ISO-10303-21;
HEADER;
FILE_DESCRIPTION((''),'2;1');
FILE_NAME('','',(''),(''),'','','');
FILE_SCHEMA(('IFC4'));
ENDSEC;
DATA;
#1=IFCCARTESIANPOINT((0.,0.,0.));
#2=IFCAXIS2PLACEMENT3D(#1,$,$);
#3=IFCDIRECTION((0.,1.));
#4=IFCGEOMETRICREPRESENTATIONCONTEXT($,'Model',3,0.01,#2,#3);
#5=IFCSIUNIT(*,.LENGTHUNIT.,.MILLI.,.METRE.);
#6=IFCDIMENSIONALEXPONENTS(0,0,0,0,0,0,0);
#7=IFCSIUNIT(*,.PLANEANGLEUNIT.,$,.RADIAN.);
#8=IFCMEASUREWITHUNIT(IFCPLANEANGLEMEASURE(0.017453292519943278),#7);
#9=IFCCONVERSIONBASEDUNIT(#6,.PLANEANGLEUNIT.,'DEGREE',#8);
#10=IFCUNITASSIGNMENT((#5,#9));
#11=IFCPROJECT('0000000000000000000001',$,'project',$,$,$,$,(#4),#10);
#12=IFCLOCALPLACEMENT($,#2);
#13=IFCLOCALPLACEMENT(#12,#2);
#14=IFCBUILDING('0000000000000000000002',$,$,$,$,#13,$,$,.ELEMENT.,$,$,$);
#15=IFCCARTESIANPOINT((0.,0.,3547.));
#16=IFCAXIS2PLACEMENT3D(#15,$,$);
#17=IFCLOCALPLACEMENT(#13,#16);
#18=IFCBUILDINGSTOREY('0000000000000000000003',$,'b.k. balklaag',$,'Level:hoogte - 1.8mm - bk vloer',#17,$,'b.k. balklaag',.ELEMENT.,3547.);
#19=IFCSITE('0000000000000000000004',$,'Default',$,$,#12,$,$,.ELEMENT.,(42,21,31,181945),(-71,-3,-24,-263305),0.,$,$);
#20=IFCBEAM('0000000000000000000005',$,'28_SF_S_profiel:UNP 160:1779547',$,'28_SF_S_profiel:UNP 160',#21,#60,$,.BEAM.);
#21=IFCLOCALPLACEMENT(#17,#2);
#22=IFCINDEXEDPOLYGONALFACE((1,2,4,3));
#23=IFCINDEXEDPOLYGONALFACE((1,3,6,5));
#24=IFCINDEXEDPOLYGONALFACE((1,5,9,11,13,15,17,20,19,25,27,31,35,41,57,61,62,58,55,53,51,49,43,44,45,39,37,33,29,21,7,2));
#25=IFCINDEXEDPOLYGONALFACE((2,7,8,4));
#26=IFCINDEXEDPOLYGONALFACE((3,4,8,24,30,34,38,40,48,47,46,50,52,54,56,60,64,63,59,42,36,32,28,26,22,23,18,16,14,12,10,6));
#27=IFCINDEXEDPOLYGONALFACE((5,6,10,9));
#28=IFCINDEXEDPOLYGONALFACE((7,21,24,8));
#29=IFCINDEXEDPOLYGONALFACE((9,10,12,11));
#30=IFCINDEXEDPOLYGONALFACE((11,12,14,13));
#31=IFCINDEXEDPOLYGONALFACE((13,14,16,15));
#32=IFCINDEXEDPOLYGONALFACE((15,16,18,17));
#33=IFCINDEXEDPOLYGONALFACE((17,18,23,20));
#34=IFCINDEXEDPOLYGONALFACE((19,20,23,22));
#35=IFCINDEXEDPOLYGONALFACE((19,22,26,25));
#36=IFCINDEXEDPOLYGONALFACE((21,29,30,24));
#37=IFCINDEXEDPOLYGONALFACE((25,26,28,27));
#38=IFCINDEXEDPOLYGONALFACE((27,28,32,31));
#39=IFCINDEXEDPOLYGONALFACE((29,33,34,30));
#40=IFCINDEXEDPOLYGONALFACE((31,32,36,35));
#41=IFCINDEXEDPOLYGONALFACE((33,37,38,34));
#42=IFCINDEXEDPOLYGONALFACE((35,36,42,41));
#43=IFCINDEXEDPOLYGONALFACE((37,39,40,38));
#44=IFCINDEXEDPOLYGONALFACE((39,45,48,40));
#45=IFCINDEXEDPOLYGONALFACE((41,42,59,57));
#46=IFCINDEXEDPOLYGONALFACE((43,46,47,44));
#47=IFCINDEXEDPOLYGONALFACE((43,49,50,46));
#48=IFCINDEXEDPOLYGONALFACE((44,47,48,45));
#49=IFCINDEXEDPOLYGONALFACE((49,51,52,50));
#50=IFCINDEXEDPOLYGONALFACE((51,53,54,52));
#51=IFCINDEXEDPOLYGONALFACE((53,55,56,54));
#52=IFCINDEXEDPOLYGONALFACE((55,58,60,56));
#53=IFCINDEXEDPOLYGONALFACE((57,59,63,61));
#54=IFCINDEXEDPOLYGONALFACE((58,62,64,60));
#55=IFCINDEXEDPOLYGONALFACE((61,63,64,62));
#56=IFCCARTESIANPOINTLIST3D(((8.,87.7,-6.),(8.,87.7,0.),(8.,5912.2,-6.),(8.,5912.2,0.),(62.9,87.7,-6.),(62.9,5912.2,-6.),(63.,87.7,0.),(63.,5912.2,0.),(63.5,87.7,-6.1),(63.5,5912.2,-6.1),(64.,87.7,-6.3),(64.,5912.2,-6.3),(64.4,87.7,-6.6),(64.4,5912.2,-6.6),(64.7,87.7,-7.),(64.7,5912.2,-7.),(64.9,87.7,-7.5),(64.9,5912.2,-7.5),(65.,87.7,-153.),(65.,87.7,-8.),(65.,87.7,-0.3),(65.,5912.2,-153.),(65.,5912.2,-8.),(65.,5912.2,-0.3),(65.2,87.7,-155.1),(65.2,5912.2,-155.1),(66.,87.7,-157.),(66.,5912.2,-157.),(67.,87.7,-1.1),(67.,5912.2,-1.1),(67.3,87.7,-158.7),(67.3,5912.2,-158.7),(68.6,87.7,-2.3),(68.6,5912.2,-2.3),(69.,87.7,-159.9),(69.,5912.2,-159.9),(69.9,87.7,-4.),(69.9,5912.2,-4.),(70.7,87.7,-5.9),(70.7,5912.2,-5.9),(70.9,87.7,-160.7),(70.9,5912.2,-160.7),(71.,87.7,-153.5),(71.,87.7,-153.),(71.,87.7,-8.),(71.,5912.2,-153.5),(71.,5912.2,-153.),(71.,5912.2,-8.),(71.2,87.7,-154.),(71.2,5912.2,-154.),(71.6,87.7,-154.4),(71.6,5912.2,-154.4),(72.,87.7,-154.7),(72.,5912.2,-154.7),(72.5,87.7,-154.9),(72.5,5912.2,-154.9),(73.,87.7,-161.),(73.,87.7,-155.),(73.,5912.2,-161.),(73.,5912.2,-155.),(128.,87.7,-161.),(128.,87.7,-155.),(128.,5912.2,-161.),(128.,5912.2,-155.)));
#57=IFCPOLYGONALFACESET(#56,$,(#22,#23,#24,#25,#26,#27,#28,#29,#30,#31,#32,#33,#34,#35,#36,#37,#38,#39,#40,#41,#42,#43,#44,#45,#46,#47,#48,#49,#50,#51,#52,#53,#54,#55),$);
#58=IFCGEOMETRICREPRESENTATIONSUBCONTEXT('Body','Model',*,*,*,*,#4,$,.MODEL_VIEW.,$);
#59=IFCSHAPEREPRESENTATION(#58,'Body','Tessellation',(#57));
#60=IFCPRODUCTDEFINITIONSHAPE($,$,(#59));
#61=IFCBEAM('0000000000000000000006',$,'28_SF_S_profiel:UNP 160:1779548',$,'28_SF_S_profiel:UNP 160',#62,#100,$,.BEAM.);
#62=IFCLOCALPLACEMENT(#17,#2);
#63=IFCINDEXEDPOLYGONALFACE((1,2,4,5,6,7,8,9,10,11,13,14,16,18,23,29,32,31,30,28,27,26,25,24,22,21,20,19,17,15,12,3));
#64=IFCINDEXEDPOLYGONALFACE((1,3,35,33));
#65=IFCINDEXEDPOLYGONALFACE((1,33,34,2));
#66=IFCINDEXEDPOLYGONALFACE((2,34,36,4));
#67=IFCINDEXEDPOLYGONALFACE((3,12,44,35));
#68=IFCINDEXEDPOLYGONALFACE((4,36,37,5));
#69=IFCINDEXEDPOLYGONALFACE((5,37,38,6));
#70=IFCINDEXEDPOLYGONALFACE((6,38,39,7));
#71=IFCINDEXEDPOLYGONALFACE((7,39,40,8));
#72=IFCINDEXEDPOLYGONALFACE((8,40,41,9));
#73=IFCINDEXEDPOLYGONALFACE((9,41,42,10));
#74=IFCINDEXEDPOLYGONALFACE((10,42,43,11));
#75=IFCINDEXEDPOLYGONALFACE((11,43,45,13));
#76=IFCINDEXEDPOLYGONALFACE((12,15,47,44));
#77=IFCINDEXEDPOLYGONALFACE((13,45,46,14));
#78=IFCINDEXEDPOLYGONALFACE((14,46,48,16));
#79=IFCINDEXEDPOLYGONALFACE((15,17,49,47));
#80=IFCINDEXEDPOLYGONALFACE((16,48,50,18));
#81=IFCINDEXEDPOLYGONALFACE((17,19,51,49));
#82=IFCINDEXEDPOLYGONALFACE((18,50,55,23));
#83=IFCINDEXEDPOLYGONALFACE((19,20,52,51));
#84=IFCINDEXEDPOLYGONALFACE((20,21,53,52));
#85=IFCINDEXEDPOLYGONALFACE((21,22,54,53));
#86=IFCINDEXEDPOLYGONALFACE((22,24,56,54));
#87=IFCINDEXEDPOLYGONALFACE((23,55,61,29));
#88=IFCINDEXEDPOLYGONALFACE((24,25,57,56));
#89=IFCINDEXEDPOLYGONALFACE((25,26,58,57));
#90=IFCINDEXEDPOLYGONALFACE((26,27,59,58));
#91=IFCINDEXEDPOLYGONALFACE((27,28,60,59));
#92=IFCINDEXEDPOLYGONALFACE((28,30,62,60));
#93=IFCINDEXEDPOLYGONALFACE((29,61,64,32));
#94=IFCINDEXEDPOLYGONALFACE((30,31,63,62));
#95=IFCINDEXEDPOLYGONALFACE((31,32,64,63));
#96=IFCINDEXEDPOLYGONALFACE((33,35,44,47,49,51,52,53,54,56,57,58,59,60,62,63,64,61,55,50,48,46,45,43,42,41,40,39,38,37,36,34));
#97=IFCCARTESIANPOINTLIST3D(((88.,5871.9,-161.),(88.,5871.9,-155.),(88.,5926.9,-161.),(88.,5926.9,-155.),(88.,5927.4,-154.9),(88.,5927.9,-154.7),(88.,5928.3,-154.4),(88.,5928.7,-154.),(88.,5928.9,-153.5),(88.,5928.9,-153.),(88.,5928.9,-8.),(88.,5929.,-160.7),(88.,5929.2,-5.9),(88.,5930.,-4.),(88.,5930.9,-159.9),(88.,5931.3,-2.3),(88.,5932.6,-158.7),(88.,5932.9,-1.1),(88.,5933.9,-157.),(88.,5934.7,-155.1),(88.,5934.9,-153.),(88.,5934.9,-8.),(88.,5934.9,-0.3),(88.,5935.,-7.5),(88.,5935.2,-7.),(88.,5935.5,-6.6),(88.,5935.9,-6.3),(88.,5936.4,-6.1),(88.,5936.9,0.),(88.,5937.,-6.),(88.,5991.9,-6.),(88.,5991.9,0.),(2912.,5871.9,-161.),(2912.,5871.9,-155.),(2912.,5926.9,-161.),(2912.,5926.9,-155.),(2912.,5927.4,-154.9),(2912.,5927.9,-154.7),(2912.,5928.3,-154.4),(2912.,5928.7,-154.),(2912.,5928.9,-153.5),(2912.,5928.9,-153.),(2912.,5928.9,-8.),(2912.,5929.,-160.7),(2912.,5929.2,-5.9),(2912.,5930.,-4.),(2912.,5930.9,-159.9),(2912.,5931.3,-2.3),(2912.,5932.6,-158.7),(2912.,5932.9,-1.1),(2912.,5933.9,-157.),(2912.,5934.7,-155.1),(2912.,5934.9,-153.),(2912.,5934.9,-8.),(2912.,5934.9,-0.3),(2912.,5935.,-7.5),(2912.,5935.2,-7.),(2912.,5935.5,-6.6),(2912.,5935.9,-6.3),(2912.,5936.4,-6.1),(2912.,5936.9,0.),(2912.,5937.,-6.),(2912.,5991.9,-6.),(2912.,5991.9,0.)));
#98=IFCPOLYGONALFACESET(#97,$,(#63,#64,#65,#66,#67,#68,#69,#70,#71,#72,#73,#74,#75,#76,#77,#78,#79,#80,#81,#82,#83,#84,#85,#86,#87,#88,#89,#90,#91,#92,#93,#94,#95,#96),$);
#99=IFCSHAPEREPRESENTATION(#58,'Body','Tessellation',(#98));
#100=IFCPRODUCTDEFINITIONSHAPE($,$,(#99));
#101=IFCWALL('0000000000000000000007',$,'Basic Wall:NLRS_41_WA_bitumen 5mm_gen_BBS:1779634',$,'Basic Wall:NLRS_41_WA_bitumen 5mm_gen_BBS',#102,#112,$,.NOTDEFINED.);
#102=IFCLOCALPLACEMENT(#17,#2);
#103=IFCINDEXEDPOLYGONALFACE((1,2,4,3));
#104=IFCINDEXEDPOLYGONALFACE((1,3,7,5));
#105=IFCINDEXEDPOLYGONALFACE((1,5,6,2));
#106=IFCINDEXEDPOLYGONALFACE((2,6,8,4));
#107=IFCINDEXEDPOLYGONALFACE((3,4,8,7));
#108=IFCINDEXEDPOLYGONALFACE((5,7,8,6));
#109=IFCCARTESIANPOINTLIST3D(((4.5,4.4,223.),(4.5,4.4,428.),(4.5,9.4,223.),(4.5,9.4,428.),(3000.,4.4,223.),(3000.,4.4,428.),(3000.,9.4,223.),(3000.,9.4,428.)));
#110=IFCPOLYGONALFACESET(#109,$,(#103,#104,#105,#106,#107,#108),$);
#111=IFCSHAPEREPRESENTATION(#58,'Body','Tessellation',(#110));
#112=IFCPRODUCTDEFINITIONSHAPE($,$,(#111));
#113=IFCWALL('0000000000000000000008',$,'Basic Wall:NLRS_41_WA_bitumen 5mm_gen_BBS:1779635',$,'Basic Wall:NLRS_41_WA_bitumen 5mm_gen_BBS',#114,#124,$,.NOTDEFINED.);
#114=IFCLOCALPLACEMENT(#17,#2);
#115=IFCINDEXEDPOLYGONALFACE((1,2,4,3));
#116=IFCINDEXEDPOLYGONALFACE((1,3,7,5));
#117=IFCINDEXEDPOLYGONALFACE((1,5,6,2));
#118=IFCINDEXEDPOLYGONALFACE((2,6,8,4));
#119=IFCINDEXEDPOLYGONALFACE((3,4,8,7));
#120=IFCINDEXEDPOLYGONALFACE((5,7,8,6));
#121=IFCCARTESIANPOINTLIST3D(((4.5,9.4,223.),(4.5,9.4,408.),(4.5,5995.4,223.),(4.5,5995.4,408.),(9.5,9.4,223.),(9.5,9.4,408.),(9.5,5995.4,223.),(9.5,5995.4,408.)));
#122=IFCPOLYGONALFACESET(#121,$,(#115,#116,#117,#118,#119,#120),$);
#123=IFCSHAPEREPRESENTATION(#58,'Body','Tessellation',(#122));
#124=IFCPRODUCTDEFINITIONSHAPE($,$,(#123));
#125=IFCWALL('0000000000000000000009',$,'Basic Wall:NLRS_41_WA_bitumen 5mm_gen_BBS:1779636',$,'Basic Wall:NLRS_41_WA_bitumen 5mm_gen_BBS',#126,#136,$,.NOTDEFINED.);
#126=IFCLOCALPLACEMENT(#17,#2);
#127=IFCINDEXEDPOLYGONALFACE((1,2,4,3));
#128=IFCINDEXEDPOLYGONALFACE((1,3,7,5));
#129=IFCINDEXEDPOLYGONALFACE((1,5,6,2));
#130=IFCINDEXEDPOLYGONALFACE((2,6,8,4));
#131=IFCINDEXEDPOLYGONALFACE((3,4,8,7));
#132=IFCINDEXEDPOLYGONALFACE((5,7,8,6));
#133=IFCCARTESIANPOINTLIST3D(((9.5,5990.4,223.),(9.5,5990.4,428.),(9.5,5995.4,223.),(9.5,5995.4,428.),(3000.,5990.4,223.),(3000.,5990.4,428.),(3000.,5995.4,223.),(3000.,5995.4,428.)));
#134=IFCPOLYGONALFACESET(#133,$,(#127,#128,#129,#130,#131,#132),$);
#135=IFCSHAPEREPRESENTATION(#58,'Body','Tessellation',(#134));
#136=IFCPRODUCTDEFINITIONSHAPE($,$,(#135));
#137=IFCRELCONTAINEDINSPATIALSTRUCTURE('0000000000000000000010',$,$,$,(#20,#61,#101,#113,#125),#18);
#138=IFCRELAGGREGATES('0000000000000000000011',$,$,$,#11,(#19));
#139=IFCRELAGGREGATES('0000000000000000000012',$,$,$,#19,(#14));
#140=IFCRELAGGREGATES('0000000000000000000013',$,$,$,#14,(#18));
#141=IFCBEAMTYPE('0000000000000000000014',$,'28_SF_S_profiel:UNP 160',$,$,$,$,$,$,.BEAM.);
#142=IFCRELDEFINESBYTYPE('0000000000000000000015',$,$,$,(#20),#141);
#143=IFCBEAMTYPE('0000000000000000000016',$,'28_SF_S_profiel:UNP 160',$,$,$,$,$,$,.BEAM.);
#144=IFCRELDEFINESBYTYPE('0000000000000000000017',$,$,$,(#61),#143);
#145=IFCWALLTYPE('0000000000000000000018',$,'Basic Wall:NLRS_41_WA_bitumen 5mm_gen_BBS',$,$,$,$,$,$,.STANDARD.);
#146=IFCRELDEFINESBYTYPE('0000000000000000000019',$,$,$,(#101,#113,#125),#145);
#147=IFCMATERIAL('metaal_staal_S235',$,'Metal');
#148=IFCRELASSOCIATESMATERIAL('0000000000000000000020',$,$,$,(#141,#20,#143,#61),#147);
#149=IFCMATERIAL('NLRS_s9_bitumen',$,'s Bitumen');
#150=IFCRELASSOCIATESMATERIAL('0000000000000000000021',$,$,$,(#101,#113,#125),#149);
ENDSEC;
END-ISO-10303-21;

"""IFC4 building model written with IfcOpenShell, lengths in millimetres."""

from ifc_helpers import new_model, entity, si_unit, converted_unit, direction, frame, origin, place, context, subcontext, project, spatial, line, arc, indexed_curve, outline, extrude, source, transform, mapped, material, type_object, type_shapes, element, save


model = new_model("IFC4")

# Units and contexts
model_context = context("Model", 3, precision=0.01, world=origin(), true_north=direction((0.0, 1.0)))
body_context = subcontext(model_context, "Body", "Model", "MODEL_VIEW")
ifc_project = project(units=[si_unit("LENGTHUNIT", "METRE", prefix="MILLI"), converted_unit("PLANEANGLEUNIT", "DEGREE", entity("IfcPlaneAngleMeasure", 0.017453292519943278), si_unit("PLANEANGLEUNIT", "RADIAN"), dimensions=[0, 0, 0, 0, 0, 0, 0])], contexts=[model_context])

# Site, building, storey
site_placement = place(None, origin())
site = spatial("IfcSite", under=ifc_project, at=site_placement, Name="Default", CompositionType="ELEMENT", RefLatitude=(42, 21, 31, 181945), RefLongitude=(-71, -3, -24, -263305), RefElevation=0.0)
building_placement = place(site_placement, origin())
building = spatial("IfcBuilding", under=site, at=building_placement, CompositionType="ELEMENT")
storey_placement = place(building_placement, frame((0.0, 0.0, 3547.0)))
storey = spatial("IfcBuildingStorey", under=building, at=storey_placement, Name="b.k. balklaag", ObjectType="Level:hoogte - 1.8mm - bk vloer", LongName="b.k. balklaag", CompositionType="ELEMENT", Elevation=3547.0)

# Beams
ifc_material_1 = material(Name="metaal_staal_S235", Category="Metal")
beam_type_1 = type_object("IfcBeamType", Name="28_SF_S_profiel:UNP 160", PredefinedType="BEAM", material=ifc_material_1)
shared_shape_1 = source(origin(), body_context, "Body", "SweptSolid", [
    extrude(outline(indexed_curve([(-60.0, -80.5), (-5.0, -80.5), (0.7, -78.2), (3.0, -72.5), (3.0, 72.5), (3.6, 73.9), (5.0, 74.5), (60.0, 74.5), (60.0, 80.5), (5.0, 80.5), (-0.7, 78.2), (-3.0, 72.5), (-3.0, -72.5), (-3.6, -73.9), (-5.0, -74.5), (-60.0, -74.5)], segments=[line(1, 2), arc(2, 3, 4), line(4, 5), arc(5, 6, 7), line(7, 8, 9, 10), arc(10, 11, 12), line(12, 13), arc(13, 14, 15), line(15, 16, 1)], self_intersect=False)), frame((-2912.0, -49.0, -4.5), z_axis=(1.0, 0.0, 0.0), x_axis=(0.0, -1.0, 0.0)), (0.0, 0.0, 1.0), 5824.5),
])
type_shapes(beam_type_1, [shared_shape_1])
beam_1_placement = place(storey_placement, frame((19.0, 2999.7, -76.0), z_axis=(0.0, 0.0, 1.0), x_axis=(0.0, 1.0, 0.0)))
element("IfcBeam", 1, at=beam_1_placement, inside=storey, type_object=beam_type_1, material=ifc_material_1, Name="28_SF_S_profiel:UNP 160:1779547", ObjectType="28_SF_S_profiel:UNP 160", PredefinedType="BEAM", context=body_context, shape_type="MappedRepresentation", body=[
    mapped(shared_shape_1, transform((0.0, 0.0, 0.0), scale=1.0)),
])
beam_type_2 = type_object("IfcBeamType", Name="28_SF_S_profiel:UNP 160", PredefinedType="BEAM", material=ifc_material_1)
shared_shape_2 = source(origin(), body_context, "Body", "SweptSolid", [
    extrude(outline(indexed_curve([(-60.0, -80.5), (-5.0, -80.5), (0.7, -78.2), (3.0, -72.5), (3.0, 72.5), (3.6, 73.9), (5.0, 74.5), (60.0, 74.5), (60.0, 80.5), (5.0, 80.5), (-0.7, 78.2), (-3.0, 72.5), (-3.0, -72.5), (-3.6, -73.9), (-5.0, -74.5), (-60.0, -74.5)], segments=[line(1, 2), arc(2, 3, 4), line(4, 5), arc(5, 6, 7), line(7, 8, 9, 10), arc(10, 11, 12), line(12, 13), arc(13, 14, 15), line(15, 16, 1)], self_intersect=False)), frame((-1412.0, -49.0, -4.5), z_axis=(1.0, 0.0, 0.0), x_axis=(0.0, -1.0, 0.0)), (0.0, 0.0, 1.0), 2824.0),
])
type_shapes(beam_type_2, [shared_shape_2])
beam_2_placement = place(storey_placement, frame((1500.0, 5980.9, -76.0)))
element("IfcBeam", 2, at=beam_2_placement, inside=storey, type_object=beam_type_2, material=ifc_material_1, Name="28_SF_S_profiel:UNP 160:1779548", ObjectType="28_SF_S_profiel:UNP 160", PredefinedType="BEAM", context=body_context, shape_type="MappedRepresentation", body=[
    mapped(shared_shape_2, transform((0.0, 0.0, 0.0), scale=1.0)),
])

# Walls
ifc_material_2 = material(Name="NLRS_s9_bitumen", Category="s Bitumen")
wall_type = type_object("IfcWallType", Name="Basic Wall:NLRS_41_WA_bitumen 5mm_gen_BBS", PredefinedType="STANDARD")
wall_1_placement = place(storey_placement, frame((3000.0, 6.9, 223.0), z_axis=(0.0, 0.0, 1.0), x_axis=(-1.0, 0.0, 0.0)))
element("IfcWall", 3, at=wall_1_placement, inside=storey, type_object=wall_type, material=ifc_material_2, Name="Basic Wall:NLRS_41_WA_bitumen 5mm_gen_BBS:1779634", ObjectType="Basic Wall:NLRS_41_WA_bitumen 5mm_gen_BBS", PredefinedType="NOTDEFINED", context=body_context, shape_type="SweptSolid", body=[
    extrude(outline(indexed_curve([(2995.5, 2.5), (0.0, 2.5), (0.0, -2.5), (2995.5, -2.5), (2995.5, 2.5)], self_intersect=False)), origin(), (0.0, 0.0, 1.0), 205.0),
])
wall_2_placement = place(storey_placement, frame((7.0, 9.4, 223.0), z_axis=(0.0, 0.0, 1.0), x_axis=(0.0, 1.0, 0.0)))
element("IfcWall", 4, at=wall_2_placement, inside=storey, type_object=wall_type, material=ifc_material_2, Name="Basic Wall:NLRS_41_WA_bitumen 5mm_gen_BBS:1779635", ObjectType="Basic Wall:NLRS_41_WA_bitumen 5mm_gen_BBS", PredefinedType="NOTDEFINED", context=body_context, shape_type="SweptSolid", body=[
    extrude(outline(indexed_curve([(5986.0, 2.5), (0.0, 2.5), (0.0, -2.5), (5986.0, -2.5), (5986.0, 2.5)], self_intersect=False)), origin(), (0.0, 0.0, 1.0), 185.0),
])
wall_3_placement = place(storey_placement, frame((9.5, 5992.9, 223.0)))
element("IfcWall", 5, at=wall_3_placement, inside=storey, type_object=wall_type, material=ifc_material_2, Name="Basic Wall:NLRS_41_WA_bitumen 5mm_gen_BBS:1779636", ObjectType="Basic Wall:NLRS_41_WA_bitumen 5mm_gen_BBS", PredefinedType="NOTDEFINED", context=body_context, shape_type="SweptSolid", body=[
    extrude(outline(indexed_curve([(2990.5, 2.5), (0.0, 2.5), (0.0, -2.5), (2990.5, -2.5), (2990.5, 2.5)], self_intersect=False)), origin(), (0.0, 0.0, 1.0), 205.0),
])

save(model, "model.ifc")
